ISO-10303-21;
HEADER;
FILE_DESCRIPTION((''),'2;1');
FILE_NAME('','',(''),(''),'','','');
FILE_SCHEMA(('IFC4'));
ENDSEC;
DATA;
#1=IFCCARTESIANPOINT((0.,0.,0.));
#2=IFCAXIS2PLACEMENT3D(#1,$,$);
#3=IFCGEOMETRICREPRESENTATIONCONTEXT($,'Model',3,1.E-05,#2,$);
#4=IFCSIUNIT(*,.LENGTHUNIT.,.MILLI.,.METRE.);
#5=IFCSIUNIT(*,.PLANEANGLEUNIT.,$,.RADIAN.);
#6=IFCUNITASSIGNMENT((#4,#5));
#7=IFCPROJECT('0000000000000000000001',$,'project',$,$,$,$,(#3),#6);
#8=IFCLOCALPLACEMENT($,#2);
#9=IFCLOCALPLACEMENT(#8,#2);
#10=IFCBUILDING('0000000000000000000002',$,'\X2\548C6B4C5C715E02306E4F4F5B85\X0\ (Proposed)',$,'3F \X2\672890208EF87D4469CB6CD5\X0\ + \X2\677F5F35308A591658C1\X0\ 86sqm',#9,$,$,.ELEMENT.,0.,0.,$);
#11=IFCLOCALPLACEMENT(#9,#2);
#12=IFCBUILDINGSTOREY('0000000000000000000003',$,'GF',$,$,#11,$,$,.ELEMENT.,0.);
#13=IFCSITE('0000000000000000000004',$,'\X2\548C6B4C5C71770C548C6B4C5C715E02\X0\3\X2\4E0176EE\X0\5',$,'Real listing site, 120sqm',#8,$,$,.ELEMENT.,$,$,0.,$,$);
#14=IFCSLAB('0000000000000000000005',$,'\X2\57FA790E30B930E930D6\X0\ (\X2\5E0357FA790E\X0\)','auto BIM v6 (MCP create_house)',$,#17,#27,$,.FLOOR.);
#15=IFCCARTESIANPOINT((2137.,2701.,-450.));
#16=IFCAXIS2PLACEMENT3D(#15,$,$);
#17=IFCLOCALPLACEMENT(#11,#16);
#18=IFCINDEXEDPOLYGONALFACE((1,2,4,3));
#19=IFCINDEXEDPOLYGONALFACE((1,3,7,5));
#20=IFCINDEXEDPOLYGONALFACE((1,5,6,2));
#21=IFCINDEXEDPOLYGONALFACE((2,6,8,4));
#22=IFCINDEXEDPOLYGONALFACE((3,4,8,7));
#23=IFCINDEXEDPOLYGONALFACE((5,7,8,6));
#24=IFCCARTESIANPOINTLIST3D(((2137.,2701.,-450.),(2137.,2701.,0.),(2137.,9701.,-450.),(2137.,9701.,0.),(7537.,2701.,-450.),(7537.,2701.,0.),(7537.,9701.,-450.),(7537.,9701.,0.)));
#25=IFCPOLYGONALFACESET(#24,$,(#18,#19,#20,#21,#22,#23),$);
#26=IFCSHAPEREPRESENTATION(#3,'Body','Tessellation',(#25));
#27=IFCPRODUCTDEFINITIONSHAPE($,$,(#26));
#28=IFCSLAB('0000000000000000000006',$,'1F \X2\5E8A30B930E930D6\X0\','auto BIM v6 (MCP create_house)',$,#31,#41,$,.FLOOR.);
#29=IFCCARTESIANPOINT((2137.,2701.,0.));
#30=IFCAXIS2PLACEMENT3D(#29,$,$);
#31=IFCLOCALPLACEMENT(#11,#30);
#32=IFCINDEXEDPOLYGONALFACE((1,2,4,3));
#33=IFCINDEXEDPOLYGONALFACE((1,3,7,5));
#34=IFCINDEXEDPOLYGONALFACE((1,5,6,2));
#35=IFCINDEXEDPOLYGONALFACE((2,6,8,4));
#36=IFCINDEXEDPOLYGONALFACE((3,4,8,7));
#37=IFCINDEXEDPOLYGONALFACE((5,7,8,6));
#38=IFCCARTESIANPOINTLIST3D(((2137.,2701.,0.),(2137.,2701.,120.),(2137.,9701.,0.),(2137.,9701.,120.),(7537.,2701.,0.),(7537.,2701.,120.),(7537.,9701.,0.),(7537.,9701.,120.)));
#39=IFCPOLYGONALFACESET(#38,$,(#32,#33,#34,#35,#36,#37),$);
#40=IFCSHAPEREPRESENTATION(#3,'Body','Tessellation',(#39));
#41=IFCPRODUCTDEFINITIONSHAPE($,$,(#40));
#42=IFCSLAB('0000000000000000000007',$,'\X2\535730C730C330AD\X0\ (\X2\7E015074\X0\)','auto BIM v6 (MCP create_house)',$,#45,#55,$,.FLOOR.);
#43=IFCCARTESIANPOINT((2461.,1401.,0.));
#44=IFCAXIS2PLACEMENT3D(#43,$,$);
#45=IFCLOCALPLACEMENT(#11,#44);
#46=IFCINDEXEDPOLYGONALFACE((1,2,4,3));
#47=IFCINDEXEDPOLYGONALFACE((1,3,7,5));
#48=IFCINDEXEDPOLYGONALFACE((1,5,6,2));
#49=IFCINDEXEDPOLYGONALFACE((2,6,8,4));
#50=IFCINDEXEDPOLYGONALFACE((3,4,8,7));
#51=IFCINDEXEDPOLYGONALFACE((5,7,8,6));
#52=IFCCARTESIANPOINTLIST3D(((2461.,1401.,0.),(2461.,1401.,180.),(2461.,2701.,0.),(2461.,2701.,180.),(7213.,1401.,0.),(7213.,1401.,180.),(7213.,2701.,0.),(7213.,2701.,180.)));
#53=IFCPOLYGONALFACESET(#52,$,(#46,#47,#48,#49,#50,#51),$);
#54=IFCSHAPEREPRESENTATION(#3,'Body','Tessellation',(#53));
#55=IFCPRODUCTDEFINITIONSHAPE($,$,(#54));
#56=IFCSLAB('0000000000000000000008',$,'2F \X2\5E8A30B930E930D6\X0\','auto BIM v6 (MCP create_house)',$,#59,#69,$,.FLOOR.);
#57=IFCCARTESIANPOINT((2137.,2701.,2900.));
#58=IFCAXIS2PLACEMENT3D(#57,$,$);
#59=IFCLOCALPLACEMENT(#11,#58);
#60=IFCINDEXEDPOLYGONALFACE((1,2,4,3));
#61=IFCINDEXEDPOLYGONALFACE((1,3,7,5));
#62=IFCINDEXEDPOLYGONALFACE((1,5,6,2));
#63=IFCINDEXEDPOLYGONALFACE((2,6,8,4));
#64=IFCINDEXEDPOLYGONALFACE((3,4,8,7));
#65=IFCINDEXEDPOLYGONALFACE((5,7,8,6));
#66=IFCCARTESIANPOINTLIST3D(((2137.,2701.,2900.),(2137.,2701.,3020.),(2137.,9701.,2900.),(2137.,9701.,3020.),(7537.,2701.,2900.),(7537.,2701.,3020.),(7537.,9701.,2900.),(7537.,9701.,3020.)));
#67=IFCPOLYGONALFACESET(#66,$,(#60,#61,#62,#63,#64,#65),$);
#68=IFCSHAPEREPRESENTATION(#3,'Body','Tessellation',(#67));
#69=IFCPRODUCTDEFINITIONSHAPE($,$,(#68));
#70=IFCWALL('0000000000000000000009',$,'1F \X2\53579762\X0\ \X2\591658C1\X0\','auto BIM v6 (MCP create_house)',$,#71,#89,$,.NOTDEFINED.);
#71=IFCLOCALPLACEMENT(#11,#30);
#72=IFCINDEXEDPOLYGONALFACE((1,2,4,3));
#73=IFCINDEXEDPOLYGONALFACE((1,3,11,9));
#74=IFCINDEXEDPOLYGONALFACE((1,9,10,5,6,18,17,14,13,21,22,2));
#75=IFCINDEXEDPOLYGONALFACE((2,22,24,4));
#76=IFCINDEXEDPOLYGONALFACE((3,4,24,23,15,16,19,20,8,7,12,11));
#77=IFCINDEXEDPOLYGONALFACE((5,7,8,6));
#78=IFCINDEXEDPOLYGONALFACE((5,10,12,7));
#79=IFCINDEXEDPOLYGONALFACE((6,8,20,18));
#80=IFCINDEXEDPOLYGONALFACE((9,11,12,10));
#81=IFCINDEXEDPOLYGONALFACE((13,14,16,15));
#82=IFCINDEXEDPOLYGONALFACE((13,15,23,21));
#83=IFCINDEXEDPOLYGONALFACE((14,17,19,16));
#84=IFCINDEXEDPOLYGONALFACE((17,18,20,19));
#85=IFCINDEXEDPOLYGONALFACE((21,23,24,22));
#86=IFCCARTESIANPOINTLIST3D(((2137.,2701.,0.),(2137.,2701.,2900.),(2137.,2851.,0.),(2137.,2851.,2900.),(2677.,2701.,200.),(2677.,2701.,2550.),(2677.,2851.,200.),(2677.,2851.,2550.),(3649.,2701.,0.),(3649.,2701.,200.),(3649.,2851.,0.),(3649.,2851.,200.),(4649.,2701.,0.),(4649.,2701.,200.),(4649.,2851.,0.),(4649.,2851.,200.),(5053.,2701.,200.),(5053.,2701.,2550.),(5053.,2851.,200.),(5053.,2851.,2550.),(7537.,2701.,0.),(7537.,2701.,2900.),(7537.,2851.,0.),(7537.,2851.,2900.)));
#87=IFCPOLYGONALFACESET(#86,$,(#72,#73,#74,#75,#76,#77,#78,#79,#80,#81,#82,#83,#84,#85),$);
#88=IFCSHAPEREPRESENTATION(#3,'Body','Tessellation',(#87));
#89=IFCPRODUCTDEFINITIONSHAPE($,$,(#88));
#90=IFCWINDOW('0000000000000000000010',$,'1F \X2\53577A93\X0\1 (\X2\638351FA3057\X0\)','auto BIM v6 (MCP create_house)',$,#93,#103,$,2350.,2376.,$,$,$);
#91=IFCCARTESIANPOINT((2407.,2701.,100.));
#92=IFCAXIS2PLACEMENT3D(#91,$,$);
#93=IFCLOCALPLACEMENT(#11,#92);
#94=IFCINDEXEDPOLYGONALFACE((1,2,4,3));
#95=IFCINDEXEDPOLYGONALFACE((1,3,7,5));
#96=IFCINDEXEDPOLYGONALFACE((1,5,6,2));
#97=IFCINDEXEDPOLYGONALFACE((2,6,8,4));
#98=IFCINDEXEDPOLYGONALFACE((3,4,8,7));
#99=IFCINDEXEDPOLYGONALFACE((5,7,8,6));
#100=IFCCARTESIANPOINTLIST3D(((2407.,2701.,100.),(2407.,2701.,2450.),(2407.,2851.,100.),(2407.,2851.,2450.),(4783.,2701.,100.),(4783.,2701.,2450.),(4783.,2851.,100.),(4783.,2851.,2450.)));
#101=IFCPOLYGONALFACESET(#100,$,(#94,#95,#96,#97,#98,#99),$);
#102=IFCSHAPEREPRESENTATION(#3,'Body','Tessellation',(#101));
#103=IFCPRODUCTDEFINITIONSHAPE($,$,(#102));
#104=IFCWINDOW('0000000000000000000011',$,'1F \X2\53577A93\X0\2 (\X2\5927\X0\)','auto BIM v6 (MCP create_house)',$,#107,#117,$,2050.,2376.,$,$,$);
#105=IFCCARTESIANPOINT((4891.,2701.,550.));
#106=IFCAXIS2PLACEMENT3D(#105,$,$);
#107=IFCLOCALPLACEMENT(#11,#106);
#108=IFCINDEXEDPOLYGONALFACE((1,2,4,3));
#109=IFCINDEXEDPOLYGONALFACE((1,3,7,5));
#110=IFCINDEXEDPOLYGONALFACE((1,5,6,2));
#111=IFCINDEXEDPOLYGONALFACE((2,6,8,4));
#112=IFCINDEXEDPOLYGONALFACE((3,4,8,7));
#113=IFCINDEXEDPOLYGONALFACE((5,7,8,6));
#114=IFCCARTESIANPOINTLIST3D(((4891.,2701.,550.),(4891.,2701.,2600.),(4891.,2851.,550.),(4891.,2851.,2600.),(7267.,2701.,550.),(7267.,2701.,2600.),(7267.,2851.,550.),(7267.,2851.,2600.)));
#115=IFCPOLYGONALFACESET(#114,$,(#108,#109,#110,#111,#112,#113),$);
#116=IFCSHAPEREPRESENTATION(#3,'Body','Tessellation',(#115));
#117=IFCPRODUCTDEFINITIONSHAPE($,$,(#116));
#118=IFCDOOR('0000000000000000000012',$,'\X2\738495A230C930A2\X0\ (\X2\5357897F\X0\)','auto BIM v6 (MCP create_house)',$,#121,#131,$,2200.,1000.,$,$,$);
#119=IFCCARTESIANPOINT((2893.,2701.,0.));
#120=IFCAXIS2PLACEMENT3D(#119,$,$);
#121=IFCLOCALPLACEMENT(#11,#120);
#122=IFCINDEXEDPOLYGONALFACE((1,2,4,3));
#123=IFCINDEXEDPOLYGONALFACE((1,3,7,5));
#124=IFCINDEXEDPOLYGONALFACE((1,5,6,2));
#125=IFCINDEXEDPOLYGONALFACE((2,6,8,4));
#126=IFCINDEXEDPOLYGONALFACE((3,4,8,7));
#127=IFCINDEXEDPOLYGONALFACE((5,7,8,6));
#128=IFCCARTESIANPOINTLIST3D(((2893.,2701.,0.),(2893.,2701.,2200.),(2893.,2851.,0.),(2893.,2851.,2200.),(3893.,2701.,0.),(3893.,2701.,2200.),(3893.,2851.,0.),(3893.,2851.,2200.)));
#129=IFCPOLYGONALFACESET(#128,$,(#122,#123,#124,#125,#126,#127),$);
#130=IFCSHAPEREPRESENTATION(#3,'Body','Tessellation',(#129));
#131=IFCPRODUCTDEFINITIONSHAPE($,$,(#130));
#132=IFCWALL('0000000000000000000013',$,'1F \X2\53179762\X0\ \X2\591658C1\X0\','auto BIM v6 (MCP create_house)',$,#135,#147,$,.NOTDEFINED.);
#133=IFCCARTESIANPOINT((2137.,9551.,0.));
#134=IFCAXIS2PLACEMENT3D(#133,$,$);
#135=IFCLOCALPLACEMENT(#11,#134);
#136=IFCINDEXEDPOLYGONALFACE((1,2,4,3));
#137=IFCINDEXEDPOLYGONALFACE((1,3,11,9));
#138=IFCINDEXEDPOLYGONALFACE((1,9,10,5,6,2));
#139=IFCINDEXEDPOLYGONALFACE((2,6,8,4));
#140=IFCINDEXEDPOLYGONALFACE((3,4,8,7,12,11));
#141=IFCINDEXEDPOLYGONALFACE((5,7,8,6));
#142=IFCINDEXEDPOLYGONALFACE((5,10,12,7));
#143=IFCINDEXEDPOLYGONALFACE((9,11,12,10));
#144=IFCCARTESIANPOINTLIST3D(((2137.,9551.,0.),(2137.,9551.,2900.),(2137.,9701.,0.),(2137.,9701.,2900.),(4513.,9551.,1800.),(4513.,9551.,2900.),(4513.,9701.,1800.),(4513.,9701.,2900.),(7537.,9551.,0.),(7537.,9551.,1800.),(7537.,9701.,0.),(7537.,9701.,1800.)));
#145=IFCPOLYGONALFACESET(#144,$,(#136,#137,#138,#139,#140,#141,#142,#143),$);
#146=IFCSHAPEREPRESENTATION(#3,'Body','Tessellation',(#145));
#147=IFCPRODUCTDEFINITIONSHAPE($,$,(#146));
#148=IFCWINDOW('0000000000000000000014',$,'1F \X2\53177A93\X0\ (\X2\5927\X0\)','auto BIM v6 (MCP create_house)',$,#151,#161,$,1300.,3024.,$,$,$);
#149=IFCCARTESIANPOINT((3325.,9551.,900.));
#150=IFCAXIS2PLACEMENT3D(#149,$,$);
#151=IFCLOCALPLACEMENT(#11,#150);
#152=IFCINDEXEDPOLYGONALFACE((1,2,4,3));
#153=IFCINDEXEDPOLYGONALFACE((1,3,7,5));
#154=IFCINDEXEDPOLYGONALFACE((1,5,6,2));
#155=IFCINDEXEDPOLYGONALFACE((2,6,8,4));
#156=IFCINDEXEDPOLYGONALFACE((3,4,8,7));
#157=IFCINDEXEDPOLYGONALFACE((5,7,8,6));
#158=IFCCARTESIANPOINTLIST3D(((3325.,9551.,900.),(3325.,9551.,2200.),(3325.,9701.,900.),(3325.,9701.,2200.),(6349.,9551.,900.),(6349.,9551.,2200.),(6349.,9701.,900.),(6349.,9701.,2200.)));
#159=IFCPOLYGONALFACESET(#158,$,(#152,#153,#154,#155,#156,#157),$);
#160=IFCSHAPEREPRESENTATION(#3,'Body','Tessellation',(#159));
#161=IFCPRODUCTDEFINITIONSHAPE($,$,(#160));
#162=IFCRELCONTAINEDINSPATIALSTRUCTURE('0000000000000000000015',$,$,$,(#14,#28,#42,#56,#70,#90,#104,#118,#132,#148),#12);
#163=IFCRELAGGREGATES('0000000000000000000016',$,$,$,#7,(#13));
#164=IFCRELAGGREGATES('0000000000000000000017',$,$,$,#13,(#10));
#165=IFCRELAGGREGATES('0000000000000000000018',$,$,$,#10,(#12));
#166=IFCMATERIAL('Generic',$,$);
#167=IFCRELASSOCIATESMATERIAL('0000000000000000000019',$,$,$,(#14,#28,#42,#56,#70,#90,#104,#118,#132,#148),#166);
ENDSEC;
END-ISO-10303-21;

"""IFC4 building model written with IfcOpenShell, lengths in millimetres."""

from ifc_helpers import new_model, si_unit, frame, frame_2d, origin, place, context, project, spatial, rectangle, extrude, material, element, fill, save


model = new_model("IFC4")

# Units and contexts
model_context = context("Model", 3, precision=1e-05, world=origin())
ifc_project = project(units=[si_unit("LENGTHUNIT", "METRE", prefix="MILLI"), si_unit("PLANEANGLEUNIT", "RADIAN")], contexts=[model_context])

# Site, building, storey
site_placement = place(None, origin())
site = spatial("IfcSite", under=ifc_project, at=site_placement, Name="和歌山県和歌山市3丁目5", ObjectType="Real listing site, 120sqm", CompositionType="ELEMENT", RefElevation=0.0)
building_placement = place(site_placement, origin())
building = spatial("IfcBuilding", under=site, at=building_placement, Name="和歌山市の住宅 (Proposed)", ObjectType="3F 木造軸組構法 + 板張り外壁 86sqm", CompositionType="ELEMENT", ElevationOfRefHeight=0.0, ElevationOfTerrain=0.0)
storey_placement = place(building_placement, origin())
storey = spatial("IfcBuildingStorey", under=building, at=storey_placement, Name="GF", CompositionType="ELEMENT", Elevation=0.0)

# Slabs
ifc_material = material(Name="Generic")
slab_1_placement = place(storey_placement, frame((2137.0, 2701.0, -450.0)))
element("IfcSlab", 1, at=slab_1_placement, inside=storey, material=ifc_material, Name="基礎スラブ (布基礎)", Description="auto BIM v6 (MCP create_house)", PredefinedType="FLOOR", context=model_context, shape_type="SweptSolid", body=[
    extrude(rectangle(XDim=5400.0, YDim=7000.0, at=frame_2d((2700.0, 3500.0))), frame((2137.0, 2701.0, -450.0)), (0.0, 0.0, 1.0), 450.0),
])
slab_2_placement = place(storey_placement, frame((2137.0, 2701.0, 0.0)))
element("IfcSlab", 2, at=slab_2_placement, inside=storey, material=ifc_material, Name="1F 床スラブ", Description="auto BIM v6 (MCP create_house)", PredefinedType="FLOOR", context=model_context, shape_type="SweptSolid", body=[
    extrude(rectangle(XDim=5400.0, YDim=7000.0, at=frame_2d((2700.0, 3500.0))), frame((2137.0, 2701.0, 0.0)), (0.0, 0.0, 1.0), 120.0),
])
slab_3_placement = place(storey_placement, frame((2461.0, 1401.0, 0.0)))
element("IfcSlab", 3, at=slab_3_placement, inside=storey, material=ifc_material, Name="南デッキ (縁側)", Description="auto BIM v6 (MCP create_house)", PredefinedType="FLOOR", context=model_context, shape_type="SweptSolid", body=[
    extrude(rectangle(XDim=4752.0, YDim=1300.0, at=frame_2d((2376.0, 650.0))), frame((2461.0, 1401.0, 0.0)), (0.0, 0.0, 1.0), 180.0),
])
slab_4_placement = place(storey_placement, frame((2137.0, 2701.0, 2900.0)))
element("IfcSlab", 4, at=slab_4_placement, inside=storey, material=ifc_material, Name="2F 床スラブ", Description="auto BIM v6 (MCP create_house)", PredefinedType="FLOOR", context=model_context, shape_type="SweptSolid", body=[
    extrude(rectangle(XDim=5400.0, YDim=7000.0, at=frame_2d((2700.0, 3500.0))), frame((2137.0, 2701.0, 2900.0)), (0.0, 0.0, 1.0), 120.0),
])

# Wall, openings, windows, door
wall_1_placement = place(storey_placement, frame((2137.0, 2701.0, 0.0)))
wall_1 = element("IfcWall", 5, at=wall_1_placement, inside=storey, material=ifc_material, Name="1F 南面 外壁", Description="auto BIM v6 (MCP create_house)", PredefinedType="NOTDEFINED", context=model_context, shape_type="SweptSolid", body=[
    extrude(rectangle(XDim=5400.0, YDim=150.0, at=frame_2d((2700.0, 75.0))), frame((2137.0, 2701.0, 0.0)), (0.0, 0.0, 1.0), 2900.0),
])
opening_1_placement = place(storey_placement, frame((2407.0, 2701.0, 100.0)))
opening_1 = element("IfcOpeningElement", 6, at=opening_1_placement, cuts=wall_1, PredefinedType="NOTDEFINED", context=model_context, shape_type="SweptSolid", body=[
    extrude(rectangle(XDim=2376.0, YDim=150.0, at=frame_2d((1188.0, 75.0))), frame((2407.0, 2701.0, 100.0)), (0.0, 0.0, 1.0), 2350.0),
])
opening_2_placement = place(storey_placement, frame((4891.0, 2701.0, 550.0)))
opening_2 = element("IfcOpeningElement", 7, at=opening_2_placement, cuts=wall_1, PredefinedType="NOTDEFINED", context=model_context, shape_type="SweptSolid", body=[
    extrude(rectangle(XDim=2376.0, YDim=150.0, at=frame_2d((1188.0, 75.0))), frame((4891.0, 2701.0, 550.0)), (0.0, 0.0, 1.0), 2050.0),
])
opening_3_placement = place(storey_placement, frame((2893.0, 2701.0, 0.0)))
opening_3 = element("IfcOpeningElement", 8, at=opening_3_placement, cuts=wall_1, PredefinedType="NOTDEFINED", context=model_context, shape_type="SweptSolid", body=[
    extrude(rectangle(XDim=1000.0, YDim=150.0, at=frame_2d((500.0, 75.0))), frame((2893.0, 2701.0, 0.0)), (0.0, 0.0, 1.0), 2200.0),
])
window_1_placement = place(storey_placement, frame((2407.0, 2701.0, 100.0)))
window_1 = element("IfcWindow", 9, at=window_1_placement, inside=storey, material=ifc_material, Name="1F 南窓1 (掃出し)", Description="auto BIM v6 (MCP create_house)", OverallHeight=2350.0, OverallWidth=2376.0, context=model_context, shape_type="SweptSolid", body=[
    extrude(rectangle(XDim=2376.0, YDim=150.0, at=frame_2d((1188.0, 75.0))), frame((2407.0, 2701.0, 100.0)), (0.0, 0.0, 1.0), 2350.0),
])
fill(opening_1, window_1)
window_2_placement = place(storey_placement, frame((4891.0, 2701.0, 550.0)))
window_2 = element("IfcWindow", 10, at=window_2_placement, inside=storey, material=ifc_material, Name="1F 南窓2 (大)", Description="auto BIM v6 (MCP create_house)", OverallHeight=2050.0, OverallWidth=2376.0, context=model_context, shape_type="SweptSolid", body=[
    extrude(rectangle(XDim=2376.0, YDim=150.0, at=frame_2d((1188.0, 75.0))), frame((4891.0, 2701.0, 550.0)), (0.0, 0.0, 1.0), 2050.0),
])
fill(opening_2, window_2)
door_placement = place(storey_placement, frame((2893.0, 2701.0, 0.0)))
door = element("IfcDoor", 11, at=door_placement, inside=storey, material=ifc_material, Name="玄関ドア (南西)", Description="auto BIM v6 (MCP create_house)", OverallHeight=2200.0, OverallWidth=1000.0, context=model_context, shape_type="SweptSolid", body=[
    extrude(rectangle(XDim=1000.0, YDim=150.0, at=frame_2d((500.0, 75.0))), frame((2893.0, 2701.0, 0.0)), (0.0, 0.0, 1.0), 2200.0),
])
fill(opening_3, door)

# Wall, opening, window
wall_2_placement = place(storey_placement, frame((2137.0, 9551.0, 0.0)))
wall_2 = element("IfcWall", 12, at=wall_2_placement, inside=storey, material=ifc_material, Name="1F 北面 外壁", Description="auto BIM v6 (MCP create_house)", PredefinedType="NOTDEFINED", context=model_context, shape_type="SweptSolid", body=[
    extrude(rectangle(XDim=5400.0, YDim=150.0, at=frame_2d((2700.0, 75.0))), frame((2137.0, 9551.0, 0.0)), (0.0, 0.0, 1.0), 2900.0),
])
opening_4_placement = place(storey_placement, frame((3325.0, 9551.0, 900.0)))
opening_4 = element("IfcOpeningElement", 13, at=opening_4_placement, cuts=wall_2, PredefinedType="NOTDEFINED", context=model_context, shape_type="SweptSolid", body=[
    extrude(rectangle(XDim=3024.0, YDim=150.0, at=frame_2d((1512.0, 75.0))), frame((3325.0, 9551.0, 900.0)), (0.0, 0.0, 1.0), 1300.0),
])
window_3_placement = place(storey_placement, frame((3325.0, 9551.0, 900.0)))
window_3 = element("IfcWindow", 14, at=window_3_placement, inside=storey, material=ifc_material, Name="1F 北窓 (大)", Description="auto BIM v6 (MCP create_house)", OverallHeight=1300.0, OverallWidth=3024.0, context=model_context, shape_type="SweptSolid", body=[
    extrude(rectangle(XDim=3024.0, YDim=150.0, at=frame_2d((1512.0, 75.0))), frame((3325.0, 9551.0, 900.0)), (0.0, 0.0, 1.0), 1300.0),
])
fill(opening_4, window_3)

save(model, "model.ifc")
